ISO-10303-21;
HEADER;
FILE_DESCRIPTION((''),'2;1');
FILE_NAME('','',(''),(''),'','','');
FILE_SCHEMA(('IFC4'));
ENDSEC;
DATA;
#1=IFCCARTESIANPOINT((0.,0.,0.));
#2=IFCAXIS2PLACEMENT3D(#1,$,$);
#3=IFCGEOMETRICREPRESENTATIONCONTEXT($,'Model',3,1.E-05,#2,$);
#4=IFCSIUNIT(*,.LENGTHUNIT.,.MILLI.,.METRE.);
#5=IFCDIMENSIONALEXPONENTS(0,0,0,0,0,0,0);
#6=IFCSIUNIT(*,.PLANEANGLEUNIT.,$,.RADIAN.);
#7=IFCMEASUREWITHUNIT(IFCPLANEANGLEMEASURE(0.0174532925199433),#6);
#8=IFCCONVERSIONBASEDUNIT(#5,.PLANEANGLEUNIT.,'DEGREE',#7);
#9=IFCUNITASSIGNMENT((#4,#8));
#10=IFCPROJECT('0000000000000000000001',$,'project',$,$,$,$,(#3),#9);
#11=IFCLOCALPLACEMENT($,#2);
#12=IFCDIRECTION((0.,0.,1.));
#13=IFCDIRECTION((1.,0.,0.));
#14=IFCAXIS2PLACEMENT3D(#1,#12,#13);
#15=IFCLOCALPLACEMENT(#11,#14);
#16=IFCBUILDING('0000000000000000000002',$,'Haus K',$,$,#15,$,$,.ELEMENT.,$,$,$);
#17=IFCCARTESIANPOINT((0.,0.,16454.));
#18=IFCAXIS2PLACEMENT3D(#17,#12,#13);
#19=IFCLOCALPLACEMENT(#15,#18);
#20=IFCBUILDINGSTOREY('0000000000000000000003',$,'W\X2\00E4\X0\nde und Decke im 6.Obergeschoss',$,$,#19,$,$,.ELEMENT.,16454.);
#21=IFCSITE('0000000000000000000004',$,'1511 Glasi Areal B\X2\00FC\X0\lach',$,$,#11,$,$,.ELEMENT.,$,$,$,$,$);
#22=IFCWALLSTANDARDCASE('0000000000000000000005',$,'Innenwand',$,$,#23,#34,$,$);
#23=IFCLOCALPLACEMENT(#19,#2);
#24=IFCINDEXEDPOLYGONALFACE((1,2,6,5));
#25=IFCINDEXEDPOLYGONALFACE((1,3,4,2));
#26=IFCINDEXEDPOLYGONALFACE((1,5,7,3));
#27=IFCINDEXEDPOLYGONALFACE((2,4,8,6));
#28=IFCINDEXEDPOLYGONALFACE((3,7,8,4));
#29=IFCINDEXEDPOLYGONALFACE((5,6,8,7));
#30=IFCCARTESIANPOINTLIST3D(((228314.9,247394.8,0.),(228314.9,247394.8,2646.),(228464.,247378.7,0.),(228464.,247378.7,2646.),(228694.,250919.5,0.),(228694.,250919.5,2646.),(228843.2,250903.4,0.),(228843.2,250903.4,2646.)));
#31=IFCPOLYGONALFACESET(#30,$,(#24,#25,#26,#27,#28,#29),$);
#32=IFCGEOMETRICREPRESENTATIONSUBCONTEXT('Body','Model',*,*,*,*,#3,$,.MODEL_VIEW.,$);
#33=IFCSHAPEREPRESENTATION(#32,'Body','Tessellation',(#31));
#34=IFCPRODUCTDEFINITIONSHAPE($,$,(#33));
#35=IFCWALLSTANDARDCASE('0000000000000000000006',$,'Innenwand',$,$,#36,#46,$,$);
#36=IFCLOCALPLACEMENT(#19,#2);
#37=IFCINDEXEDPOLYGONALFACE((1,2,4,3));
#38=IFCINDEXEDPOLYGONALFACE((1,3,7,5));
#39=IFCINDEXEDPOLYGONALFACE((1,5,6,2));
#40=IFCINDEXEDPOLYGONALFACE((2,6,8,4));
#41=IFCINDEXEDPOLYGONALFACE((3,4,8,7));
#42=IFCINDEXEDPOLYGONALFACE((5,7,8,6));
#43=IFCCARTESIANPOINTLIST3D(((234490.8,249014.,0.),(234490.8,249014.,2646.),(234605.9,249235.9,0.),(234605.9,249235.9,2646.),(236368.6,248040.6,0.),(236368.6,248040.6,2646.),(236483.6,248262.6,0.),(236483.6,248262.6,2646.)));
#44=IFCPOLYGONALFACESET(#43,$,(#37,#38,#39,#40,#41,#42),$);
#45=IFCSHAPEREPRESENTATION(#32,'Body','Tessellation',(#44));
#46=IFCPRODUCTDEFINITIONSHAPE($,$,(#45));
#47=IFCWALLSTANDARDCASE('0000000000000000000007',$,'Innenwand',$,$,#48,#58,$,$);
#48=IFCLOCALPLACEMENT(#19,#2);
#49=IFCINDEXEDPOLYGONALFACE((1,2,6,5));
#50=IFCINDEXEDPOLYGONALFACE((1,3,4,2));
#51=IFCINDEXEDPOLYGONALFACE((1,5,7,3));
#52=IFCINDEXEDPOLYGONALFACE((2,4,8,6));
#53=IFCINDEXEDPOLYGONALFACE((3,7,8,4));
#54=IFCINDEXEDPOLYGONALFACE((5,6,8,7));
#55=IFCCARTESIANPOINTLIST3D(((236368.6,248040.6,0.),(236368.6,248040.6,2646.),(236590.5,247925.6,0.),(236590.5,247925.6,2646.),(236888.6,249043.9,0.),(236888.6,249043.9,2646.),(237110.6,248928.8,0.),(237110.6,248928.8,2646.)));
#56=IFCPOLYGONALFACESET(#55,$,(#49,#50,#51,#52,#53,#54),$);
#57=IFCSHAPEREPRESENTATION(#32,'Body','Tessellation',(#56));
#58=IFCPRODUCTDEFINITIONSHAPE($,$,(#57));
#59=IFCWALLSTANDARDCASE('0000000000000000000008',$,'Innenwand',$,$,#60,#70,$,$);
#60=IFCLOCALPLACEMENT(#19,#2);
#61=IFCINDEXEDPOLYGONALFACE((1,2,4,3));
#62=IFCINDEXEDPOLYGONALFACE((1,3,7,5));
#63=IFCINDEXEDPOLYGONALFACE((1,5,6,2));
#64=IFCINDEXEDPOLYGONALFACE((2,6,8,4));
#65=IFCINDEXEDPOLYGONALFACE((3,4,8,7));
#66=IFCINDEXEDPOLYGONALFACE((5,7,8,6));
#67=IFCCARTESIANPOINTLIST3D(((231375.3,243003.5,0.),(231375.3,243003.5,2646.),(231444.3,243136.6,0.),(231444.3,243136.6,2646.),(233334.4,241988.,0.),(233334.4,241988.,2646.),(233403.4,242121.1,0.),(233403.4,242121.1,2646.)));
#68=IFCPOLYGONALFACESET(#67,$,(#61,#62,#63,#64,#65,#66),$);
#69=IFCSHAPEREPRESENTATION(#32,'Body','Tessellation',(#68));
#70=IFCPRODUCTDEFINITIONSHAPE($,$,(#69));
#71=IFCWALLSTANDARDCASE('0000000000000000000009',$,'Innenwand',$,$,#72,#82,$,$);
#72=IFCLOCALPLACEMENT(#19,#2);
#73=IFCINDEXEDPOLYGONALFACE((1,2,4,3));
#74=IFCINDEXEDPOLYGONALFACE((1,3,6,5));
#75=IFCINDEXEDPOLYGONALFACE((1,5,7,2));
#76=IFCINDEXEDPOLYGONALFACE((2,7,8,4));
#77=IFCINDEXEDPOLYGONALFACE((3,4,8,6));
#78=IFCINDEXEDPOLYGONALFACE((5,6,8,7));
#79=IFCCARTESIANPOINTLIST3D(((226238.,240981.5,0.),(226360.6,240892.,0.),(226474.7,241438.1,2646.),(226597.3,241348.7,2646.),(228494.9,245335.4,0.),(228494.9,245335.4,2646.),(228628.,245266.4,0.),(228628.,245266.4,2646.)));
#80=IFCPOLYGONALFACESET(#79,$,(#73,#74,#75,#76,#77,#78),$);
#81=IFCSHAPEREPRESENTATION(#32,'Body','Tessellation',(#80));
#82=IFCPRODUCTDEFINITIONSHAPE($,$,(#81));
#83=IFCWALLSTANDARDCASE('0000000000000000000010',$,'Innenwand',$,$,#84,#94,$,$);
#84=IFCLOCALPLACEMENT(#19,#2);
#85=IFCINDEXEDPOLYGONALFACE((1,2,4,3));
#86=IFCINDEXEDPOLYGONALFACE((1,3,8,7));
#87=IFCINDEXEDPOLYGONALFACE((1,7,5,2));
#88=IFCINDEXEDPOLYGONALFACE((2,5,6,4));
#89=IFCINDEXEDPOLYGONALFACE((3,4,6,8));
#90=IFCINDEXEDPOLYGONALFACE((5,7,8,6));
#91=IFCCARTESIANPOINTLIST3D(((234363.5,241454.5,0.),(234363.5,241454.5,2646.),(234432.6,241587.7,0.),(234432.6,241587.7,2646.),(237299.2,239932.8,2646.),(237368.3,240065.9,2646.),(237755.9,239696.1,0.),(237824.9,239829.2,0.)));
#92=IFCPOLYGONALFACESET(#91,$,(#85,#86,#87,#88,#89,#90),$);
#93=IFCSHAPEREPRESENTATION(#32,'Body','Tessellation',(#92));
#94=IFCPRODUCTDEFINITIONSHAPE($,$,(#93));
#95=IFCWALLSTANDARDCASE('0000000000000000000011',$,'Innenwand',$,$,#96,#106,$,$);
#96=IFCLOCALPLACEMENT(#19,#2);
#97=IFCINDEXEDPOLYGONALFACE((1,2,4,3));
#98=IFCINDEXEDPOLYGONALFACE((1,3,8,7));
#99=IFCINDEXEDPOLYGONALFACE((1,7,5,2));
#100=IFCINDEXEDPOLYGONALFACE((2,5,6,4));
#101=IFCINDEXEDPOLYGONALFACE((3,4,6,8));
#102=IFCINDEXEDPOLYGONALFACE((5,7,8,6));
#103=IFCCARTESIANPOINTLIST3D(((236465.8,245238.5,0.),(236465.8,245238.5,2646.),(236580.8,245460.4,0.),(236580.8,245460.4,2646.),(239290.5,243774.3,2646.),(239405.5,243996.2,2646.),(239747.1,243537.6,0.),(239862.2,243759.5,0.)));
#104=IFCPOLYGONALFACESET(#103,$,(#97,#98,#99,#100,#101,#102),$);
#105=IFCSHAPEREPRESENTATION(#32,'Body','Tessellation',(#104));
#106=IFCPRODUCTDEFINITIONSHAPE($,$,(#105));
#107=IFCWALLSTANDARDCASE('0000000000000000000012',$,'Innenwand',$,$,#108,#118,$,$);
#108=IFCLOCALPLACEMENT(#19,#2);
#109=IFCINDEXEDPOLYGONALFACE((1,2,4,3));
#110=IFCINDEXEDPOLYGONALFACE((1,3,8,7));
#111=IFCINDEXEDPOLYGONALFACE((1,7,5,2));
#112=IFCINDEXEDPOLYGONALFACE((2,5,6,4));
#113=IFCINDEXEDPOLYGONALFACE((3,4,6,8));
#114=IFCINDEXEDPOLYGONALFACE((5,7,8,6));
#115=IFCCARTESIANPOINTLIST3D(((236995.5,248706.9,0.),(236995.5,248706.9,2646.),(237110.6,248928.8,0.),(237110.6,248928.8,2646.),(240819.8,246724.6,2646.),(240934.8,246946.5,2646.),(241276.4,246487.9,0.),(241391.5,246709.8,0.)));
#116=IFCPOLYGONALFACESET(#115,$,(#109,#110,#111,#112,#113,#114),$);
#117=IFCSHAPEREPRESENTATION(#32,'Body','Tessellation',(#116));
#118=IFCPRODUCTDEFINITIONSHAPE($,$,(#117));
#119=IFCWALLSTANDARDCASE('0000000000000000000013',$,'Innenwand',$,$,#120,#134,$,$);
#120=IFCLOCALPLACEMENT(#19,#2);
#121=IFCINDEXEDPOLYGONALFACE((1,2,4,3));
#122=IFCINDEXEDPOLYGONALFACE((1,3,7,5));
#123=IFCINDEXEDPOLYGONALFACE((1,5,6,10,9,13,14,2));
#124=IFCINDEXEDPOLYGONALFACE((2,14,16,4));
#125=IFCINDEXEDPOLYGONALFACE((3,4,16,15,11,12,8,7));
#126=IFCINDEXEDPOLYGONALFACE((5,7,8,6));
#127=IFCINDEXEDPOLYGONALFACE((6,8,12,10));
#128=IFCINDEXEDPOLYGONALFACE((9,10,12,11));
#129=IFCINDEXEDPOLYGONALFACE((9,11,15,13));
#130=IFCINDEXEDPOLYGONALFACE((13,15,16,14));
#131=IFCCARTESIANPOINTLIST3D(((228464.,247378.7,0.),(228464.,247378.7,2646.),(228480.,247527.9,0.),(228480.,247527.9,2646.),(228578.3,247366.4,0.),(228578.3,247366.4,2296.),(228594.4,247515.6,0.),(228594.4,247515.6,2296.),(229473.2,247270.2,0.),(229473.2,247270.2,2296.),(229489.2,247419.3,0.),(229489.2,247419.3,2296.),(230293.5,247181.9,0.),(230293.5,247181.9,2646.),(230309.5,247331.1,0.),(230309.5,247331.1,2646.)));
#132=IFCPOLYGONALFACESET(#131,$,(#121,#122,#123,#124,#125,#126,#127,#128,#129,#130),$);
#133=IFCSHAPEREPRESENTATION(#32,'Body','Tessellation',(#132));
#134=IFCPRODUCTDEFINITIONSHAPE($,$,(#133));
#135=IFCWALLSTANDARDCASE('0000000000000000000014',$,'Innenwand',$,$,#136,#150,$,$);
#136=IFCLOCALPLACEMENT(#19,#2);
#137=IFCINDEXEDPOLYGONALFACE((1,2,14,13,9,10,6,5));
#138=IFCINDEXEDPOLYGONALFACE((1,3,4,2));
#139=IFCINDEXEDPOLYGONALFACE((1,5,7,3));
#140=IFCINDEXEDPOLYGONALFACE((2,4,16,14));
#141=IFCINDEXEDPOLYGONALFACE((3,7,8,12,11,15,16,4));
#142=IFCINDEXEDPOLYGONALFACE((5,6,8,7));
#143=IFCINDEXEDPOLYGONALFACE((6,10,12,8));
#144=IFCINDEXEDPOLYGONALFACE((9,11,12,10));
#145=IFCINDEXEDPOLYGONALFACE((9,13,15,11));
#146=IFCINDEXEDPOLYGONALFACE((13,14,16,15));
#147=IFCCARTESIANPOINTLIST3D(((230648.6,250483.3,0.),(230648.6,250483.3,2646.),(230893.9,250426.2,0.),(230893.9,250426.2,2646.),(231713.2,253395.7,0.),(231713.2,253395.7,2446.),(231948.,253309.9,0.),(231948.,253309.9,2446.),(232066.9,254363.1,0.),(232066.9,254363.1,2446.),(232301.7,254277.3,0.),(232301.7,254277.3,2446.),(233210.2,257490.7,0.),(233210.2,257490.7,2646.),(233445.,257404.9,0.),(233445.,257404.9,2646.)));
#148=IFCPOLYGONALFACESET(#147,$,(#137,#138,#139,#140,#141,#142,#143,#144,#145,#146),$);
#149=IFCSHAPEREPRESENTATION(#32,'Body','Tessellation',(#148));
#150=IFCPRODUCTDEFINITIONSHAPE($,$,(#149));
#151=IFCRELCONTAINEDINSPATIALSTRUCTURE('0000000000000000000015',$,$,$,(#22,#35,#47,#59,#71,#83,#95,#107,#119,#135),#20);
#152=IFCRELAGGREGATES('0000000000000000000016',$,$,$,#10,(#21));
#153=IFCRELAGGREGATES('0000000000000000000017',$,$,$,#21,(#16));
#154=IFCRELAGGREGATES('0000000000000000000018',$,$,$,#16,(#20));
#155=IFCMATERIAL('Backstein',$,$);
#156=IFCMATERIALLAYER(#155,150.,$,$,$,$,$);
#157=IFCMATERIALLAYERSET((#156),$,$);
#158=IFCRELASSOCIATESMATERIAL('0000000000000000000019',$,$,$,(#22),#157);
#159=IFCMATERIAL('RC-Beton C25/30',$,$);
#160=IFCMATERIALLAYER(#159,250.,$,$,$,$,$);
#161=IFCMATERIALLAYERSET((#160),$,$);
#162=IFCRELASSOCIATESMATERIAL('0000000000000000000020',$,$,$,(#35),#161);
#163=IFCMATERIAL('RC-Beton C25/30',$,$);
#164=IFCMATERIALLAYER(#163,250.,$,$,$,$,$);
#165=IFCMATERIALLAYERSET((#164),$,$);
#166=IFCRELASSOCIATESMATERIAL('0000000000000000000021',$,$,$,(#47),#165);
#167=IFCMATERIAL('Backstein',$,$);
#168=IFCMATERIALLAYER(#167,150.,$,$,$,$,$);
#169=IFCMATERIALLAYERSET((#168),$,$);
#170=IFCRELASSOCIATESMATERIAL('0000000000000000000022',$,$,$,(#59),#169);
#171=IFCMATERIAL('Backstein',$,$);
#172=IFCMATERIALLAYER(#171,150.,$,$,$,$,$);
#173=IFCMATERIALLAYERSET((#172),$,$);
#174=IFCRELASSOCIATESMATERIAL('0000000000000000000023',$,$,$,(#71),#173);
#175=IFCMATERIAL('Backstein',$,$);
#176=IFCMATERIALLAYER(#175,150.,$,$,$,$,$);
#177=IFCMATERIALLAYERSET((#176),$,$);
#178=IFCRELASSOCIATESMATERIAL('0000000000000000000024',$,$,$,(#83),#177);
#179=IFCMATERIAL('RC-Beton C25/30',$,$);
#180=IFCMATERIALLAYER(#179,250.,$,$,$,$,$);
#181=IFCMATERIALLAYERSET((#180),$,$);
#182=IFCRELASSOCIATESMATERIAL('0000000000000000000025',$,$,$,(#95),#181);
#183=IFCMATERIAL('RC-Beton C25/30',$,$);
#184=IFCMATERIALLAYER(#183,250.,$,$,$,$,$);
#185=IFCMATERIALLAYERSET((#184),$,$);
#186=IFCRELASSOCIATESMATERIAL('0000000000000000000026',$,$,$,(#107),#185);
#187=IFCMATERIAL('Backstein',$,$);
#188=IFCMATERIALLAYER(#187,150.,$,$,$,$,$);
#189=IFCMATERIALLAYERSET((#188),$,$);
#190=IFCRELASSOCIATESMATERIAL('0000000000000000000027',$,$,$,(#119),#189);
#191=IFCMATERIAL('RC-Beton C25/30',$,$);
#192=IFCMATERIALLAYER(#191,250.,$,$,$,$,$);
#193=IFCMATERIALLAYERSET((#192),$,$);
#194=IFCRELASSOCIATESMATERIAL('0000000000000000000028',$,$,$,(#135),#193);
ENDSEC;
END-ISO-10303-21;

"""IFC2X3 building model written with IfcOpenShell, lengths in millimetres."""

from ifc_helpers import new_model, entity, si_unit, converted_unit, frame, frame_2d, origin, origin_with_axes, place, context, subcontext, project, spatial, polyline, rectangle, outline, extrude, clip, bounded_halfspace, material, layer, layer_set, layer_usage, element, save


model = new_model("IFC2X3")

# Units and contexts
model_context = context("Model", 3, precision=1e-05, world=origin())
body_context = subcontext(model_context, "Body", "Model", "MODEL_VIEW")
ifc_project = project(units=[si_unit("LENGTHUNIT", "METRE", prefix="MILLI"), converted_unit("PLANEANGLEUNIT", "DEGREE", entity("IfcPlaneAngleMeasure", 0.0174532925199433), si_unit("PLANEANGLEUNIT", "RADIAN"), dimensions=[0, 0, 0, 0, 0, 0, 0])], contexts=[model_context])

# Site, building, storey
site_placement = place(None, origin())
site = spatial("IfcSite", under=ifc_project, at=site_placement, Name="1511 Glasi Areal Bülach", CompositionType="ELEMENT")
building_placement = place(site_placement, origin_with_axes())
building = spatial("IfcBuilding", under=site, at=building_placement, Name="Haus K", CompositionType="ELEMENT")
storey_placement = place(building_placement, frame((0.0, 0.0, 16454.0), z_axis=(0.0, 0.0, 1.0), x_axis=(1.0, 0.0, 0.0)))
storey = spatial("IfcBuildingStorey", under=building, at=storey_placement, Name="Wände und Decke im 6.Obergeschoss", CompositionType="ELEMENT", Elevation=16454.0)

# Walls
ifc_material_1 = material(Name="Backstein")
ifc_layer_1 = layer(ifc_material_1, 150.0)
ifc_layer_set_1 = layer_set([ifc_layer_1])
ifc_layer_usage_1 = layer_usage(ifc_layer_set_1, "AXIS2", "POSITIVE", 0.0)
wall_1_placement = place(storey_placement, frame((228694.0, 250919.5, 0.0), z_axis=(0.0, 0.0, 1.0), x_axis=(-0.106958, -0.994264, 0.0)))
element("IfcWallStandardCase", 1, at=wall_1_placement, inside=storey, material=ifc_layer_usage_1, Name="Innenwand", context=body_context, shape_type="SweptSolid", body=[
    extrude(rectangle(XDim=3545.0, YDim=150.0, at=frame_2d((1772.5, 75.0), x_axis=(1.0, 0.0))), origin_with_axes(), (0.0, 0.0, 1.0), 2646.0),
])
ifc_material_2 = material(Name="RC-Beton C25/30")
ifc_layer_2 = layer(ifc_material_2, 250.0)
ifc_layer_set_2 = layer_set([ifc_layer_2])
ifc_layer_usage_2 = layer_usage(ifc_layer_set_2, "AXIS2", "POSITIVE", 0.0)
wall_2_placement = place(storey_placement, frame((236483.6, 248262.6, 0.0), z_axis=(0.0, 0.0, 1.0), x_axis=(-0.887815, 0.4602, 0.0)))
element("IfcWallStandardCase", 2, at=wall_2_placement, inside=storey, material=ifc_layer_usage_2, Name="Innenwand", context=body_context, shape_type="SweptSolid", body=[
    extrude(rectangle(XDim=2115.0, YDim=250.0, at=frame_2d((1057.5, 125.0), x_axis=(1.0, 0.0))), origin_with_axes(), (0.0, 0.0, 1.0), 2646.0),
])
ifc_material_3 = material(Name="RC-Beton C25/30")
ifc_layer_3 = layer(ifc_material_3, 250.0)
ifc_layer_set_3 = layer_set([ifc_layer_3])
ifc_layer_usage_3 = layer_usage(ifc_layer_set_3, "AXIS2", "POSITIVE", 0.0)
wall_3_placement = place(storey_placement, frame((236590.5, 247925.6, 0.0), z_axis=(0.0, 0.0, 1.0), x_axis=(0.4602, 0.887815, 0.0)))
element("IfcWallStandardCase", 3, at=wall_3_placement, inside=storey, material=ifc_layer_usage_3, Name="Innenwand", context=body_context, shape_type="SweptSolid", body=[
    extrude(rectangle(XDim=1130.0, YDim=250.0, at=frame_2d((565.0, 125.0), x_axis=(1.0, 0.0))), origin_with_axes(), (0.0, 0.0, 1.0), 2646.0),
])
ifc_material_4 = material(Name="Backstein")
ifc_layer_4 = layer(ifc_material_4, 150.0)
ifc_layer_set_4 = layer_set([ifc_layer_4])
ifc_layer_usage_4 = layer_usage(ifc_layer_set_4, "AXIS2", "POSITIVE", 0.0)
wall_4_placement = place(storey_placement, frame((233403.4, 242121.1, 0.0), z_axis=(0.0, 0.0, 1.0), x_axis=(-0.887815, 0.4602, 0.0)))
element("IfcWallStandardCase", 4, at=wall_4_placement, inside=storey, material=ifc_layer_usage_4, Name="Innenwand", context=body_context, shape_type="SweptSolid", body=[
    extrude(rectangle(XDim=2206.6, YDim=150.0, at=frame_2d((1103.3, 75.0), x_axis=(1.0, 0.0))), origin_with_axes(), (0.0, 0.0, 1.0), 2646.0),
])
ifc_material_5 = material(Name="Backstein")
ifc_layer_5 = layer(ifc_material_5, 150.0)
ifc_layer_set_5 = layer_set([ifc_layer_5])
ifc_layer_usage_5 = layer_usage(ifc_layer_set_5, "AXIS2", "POSITIVE", 0.0)
wall_5_placement = place(storey_placement, frame((228494.9, 245335.4, 0.0), z_axis=(0.0, 0.0, 1.0), x_axis=(-0.4602, -0.887815, 0.0)))
element("IfcWallStandardCase", 5, at=wall_5_placement, inside=storey, material=ifc_layer_usage_5, Name="Innenwand", context=body_context, shape_type="Clipping", body=[
    clip(clip(extrude(outline(polyline([(0.0, 0.0), (4904.1, 0.0), (4927.1, 150.0), (0.0, 150.0), (0.0, 0.0)])), origin_with_axes(), (0.0, 0.0, 1.0), 2646.0), bounded_halfspace(frame((4389.8, 0.0, 2646.0), z_axis=(-0.970662, 0.149052, -0.188678), x_axis=(0.190809, 0.0, -0.981627)), True, origin(), polyline([(4389.8, 0.0), (4904.1, 0.0), (4927.1, 150.0), (4412.8, 150.0), (4389.8, 0.0)]))), bounded_halfspace(frame((4389.8, 0.0, 2646.0), z_axis=(0.0, 0.0, -1.0), x_axis=(0.151778, 0.988415, 0.0)), True, origin(), polyline([(4389.8, 0.0), (4412.8, 150.0), (0.0, 150.0), (0.0, 0.0), (4389.8, 0.0)]))),
])
ifc_material_6 = material(Name="Backstein")
ifc_layer_6 = layer(ifc_material_6, 150.0)
ifc_layer_set_6 = layer_set([ifc_layer_6])
ifc_layer_usage_6 = layer_usage(ifc_layer_set_6, "AXIS2", "POSITIVE", 0.0)
wall_6_placement = place(storey_placement, frame((237824.9, 239829.2, 0.0), z_axis=(0.0, 0.0, 1.0), x_axis=(-0.887815, 0.4602, 0.0)))
element("IfcWallStandardCase", 6, at=wall_6_placement, inside=storey, material=ifc_layer_usage_6, Name="Innenwand", context=body_context, shape_type="Clipping", body=[
    clip(clip(extrude(rectangle(XDim=3821.0, YDim=150.0, at=frame_2d((1910.5, 75.0), x_axis=(1.0, 0.0))), origin_with_axes(), (0.0, 0.0, 1.0), 2646.0), bounded_halfspace(frame((514.3, 150.0, 2646.0), z_axis=(0.981627, 0.0, -0.190809), x_axis=(-0.190809, 0.0, -0.981627)), True, origin(), polyline([(514.3, 150.0), (0.0, 150.0), (0.0, 0.0), (514.3, 0.0), (514.3, 150.0)]))), bounded_halfspace(frame((514.3, 150.0, 2646.0), z_axis=(0.0, 0.0, -1.0), x_axis=(0.0, -1.0, 0.0)), True, origin(), polyline([(514.3, 150.0), (514.3, 0.0), (3821.0, 0.0), (3821.0, 150.0), (514.3, 150.0)]))),
])
ifc_material_7 = material(Name="RC-Beton C25/30")
ifc_layer_7 = layer(ifc_material_7, 250.0)
ifc_layer_set_7 = layer_set([ifc_layer_7])
ifc_layer_usage_7 = layer_usage(ifc_layer_set_7, "AXIS2", "POSITIVE", 0.0)
wall_7_placement = place(storey_placement, frame((239862.2, 243759.5, 0.0), z_axis=(0.0, 0.0, 1.0), x_axis=(-0.887815, 0.4602, 0.0)))
element("IfcWallStandardCase", 7, at=wall_7_placement, inside=storey, material=ifc_layer_usage_7, Name="Innenwand", context=body_context, shape_type="Clipping", body=[
    clip(clip(extrude(rectangle(XDim=3696.0, YDim=250.0, at=frame_2d((1848.0, 125.0), x_axis=(1.0, 0.0))), origin_with_axes(), (0.0, 0.0, 1.0), 2646.0), bounded_halfspace(frame((514.3, 250.0, 2646.0), z_axis=(0.981627, 0.0, -0.190809), x_axis=(-0.190809, 0.0, -0.981627)), True, origin(), polyline([(514.3, 250.0), (0.0, 250.0), (0.0, 0.0), (514.3, 0.0), (514.3, 250.0)]))), bounded_halfspace(frame((514.3, 250.0, 2646.0), z_axis=(0.0, 0.0, -1.0), x_axis=(0.0, -1.0, 0.0)), True, origin(), polyline([(514.3, 250.0), (514.3, 0.0), (3696.0, 0.0), (3696.0, 250.0), (514.3, 250.0)]))),
])
ifc_material_8 = material(Name="RC-Beton C25/30")
ifc_layer_8 = layer(ifc_material_8, 250.0)
ifc_layer_set_8 = layer_set([ifc_layer_8])
ifc_layer_usage_8 = layer_usage(ifc_layer_set_8, "AXIS2", "POSITIVE", 0.0)
wall_8_placement = place(storey_placement, frame((236995.5, 248706.9, 0.0), z_axis=(0.0, 0.0, 1.0), x_axis=(0.887815, -0.4602, 0.0)))
element("IfcWallStandardCase", 8, at=wall_8_placement, inside=storey, material=ifc_layer_usage_8, Name="Innenwand", context=body_context, shape_type="Clipping", body=[
    clip(clip(extrude(rectangle(XDim=4821.8, YDim=250.0, at=frame_2d((2410.9, 125.0), x_axis=(1.0, 0.0))), origin_with_axes(), (0.0, 0.0, 1.0), 2646.0), bounded_halfspace(frame((4307.5, 0.0, 2646.0), z_axis=(-0.981627, 0.0, -0.190809), x_axis=(0.190809, 0.0, -0.981627)), True, origin(), polyline([(4307.5, 0.0), (4821.8, 0.0), (4821.8, 250.0), (4307.5, 250.0), (4307.5, 0.0)]))), bounded_halfspace(frame((4307.5, 0.0, 2646.0), z_axis=(0.0, 0.0, -1.0), x_axis=(0.0, 1.0, 0.0)), True, origin(), polyline([(4307.5, 0.0), (4307.5, 250.0), (0.0, 250.0), (0.0, 0.0), (4307.5, 0.0)]))),
])

# Walls, openings
ifc_material_9 = material(Name="Backstein")
ifc_layer_9 = layer(ifc_material_9, 150.0)
ifc_layer_set_9 = layer_set([ifc_layer_9])
ifc_layer_usage_9 = layer_usage(ifc_layer_set_9, "AXIS2", "POSITIVE", 0.0)
wall_9_placement = place(storey_placement, frame((228464.0, 247378.7, 0.0), z_axis=(0.0, 0.0, 1.0), x_axis=(0.994264, -0.106958, 0.0)))
wall_9 = element("IfcWallStandardCase", 9, at=wall_9_placement, inside=storey, material=ifc_layer_usage_9, Name="Innenwand", context=body_context, shape_type="SweptSolid", body=[
    extrude(rectangle(XDim=1840.0, YDim=150.0, at=frame_2d((920.0, 75.0), x_axis=(1.0, 0.0))), origin_with_axes(), (0.0, 0.0, 1.0), 2646.0),
])
opening_1_placement = place(wall_9_placement, frame((115.0, 0.0, 0.0), z_axis=(0.0, 1.0, 0.0), x_axis=(0.0, 0.0, 1.0)))
element("IfcOpeningElement", 10, at=opening_1_placement, cuts=wall_9, ObjectType="Opening", context=body_context, shape_type="SweptSolid", body=[
    extrude(rectangle(XDim=2296.0, YDim=900.0, at=frame_2d((1148.0, 450.0), x_axis=(1.0, 0.0))), origin_with_axes(), (0.0, 0.0, 1.0), 150.0),
])
ifc_material_10 = material(Name="RC-Beton C25/30")
ifc_layer_10 = layer(ifc_material_10, 250.0)
ifc_layer_set_10 = layer_set([ifc_layer_10])
ifc_layer_usage_10 = layer_usage(ifc_layer_set_10, "AXIS2", "POSITIVE", 0.0)
wall_10_placement = place(storey_placement, frame((230893.9, 250426.2, 0.0), z_axis=(0.0, 0.0, 1.0), x_axis=(0.343332, 0.939214, 0.0)))
wall_10 = element("IfcWallStandardCase", 11, at=wall_10_placement, inside=storey, material=ifc_layer_usage_10, Name="Innenwand", context=body_context, shape_type="SweptSolid", body=[
    extrude(outline(polyline([(0.0, 0.0), (7430.3, 0.0), (7430.3, 250.0), (-30.6, 250.0), (0.0, 0.0)])), origin_with_axes(), (0.0, 0.0, 1.0), 2646.0),
])
opening_2_placement = place(wall_10_placement, frame((3070.3, 0.0, 0.0), z_axis=(0.0, 1.0, 0.0), x_axis=(0.0, 0.0, 1.0)))
element("IfcOpeningElement", 12, at=opening_2_placement, cuts=wall_10, ObjectType="Opening", context=body_context, shape_type="SweptSolid", body=[
    extrude(rectangle(XDim=2446.0, YDim=1030.0, at=frame_2d((1223.0, 515.0), x_axis=(1.0, 0.0))), origin_with_axes(), (0.0, 0.0, 1.0), 250.0),
])

save(model, "model.ifc")
